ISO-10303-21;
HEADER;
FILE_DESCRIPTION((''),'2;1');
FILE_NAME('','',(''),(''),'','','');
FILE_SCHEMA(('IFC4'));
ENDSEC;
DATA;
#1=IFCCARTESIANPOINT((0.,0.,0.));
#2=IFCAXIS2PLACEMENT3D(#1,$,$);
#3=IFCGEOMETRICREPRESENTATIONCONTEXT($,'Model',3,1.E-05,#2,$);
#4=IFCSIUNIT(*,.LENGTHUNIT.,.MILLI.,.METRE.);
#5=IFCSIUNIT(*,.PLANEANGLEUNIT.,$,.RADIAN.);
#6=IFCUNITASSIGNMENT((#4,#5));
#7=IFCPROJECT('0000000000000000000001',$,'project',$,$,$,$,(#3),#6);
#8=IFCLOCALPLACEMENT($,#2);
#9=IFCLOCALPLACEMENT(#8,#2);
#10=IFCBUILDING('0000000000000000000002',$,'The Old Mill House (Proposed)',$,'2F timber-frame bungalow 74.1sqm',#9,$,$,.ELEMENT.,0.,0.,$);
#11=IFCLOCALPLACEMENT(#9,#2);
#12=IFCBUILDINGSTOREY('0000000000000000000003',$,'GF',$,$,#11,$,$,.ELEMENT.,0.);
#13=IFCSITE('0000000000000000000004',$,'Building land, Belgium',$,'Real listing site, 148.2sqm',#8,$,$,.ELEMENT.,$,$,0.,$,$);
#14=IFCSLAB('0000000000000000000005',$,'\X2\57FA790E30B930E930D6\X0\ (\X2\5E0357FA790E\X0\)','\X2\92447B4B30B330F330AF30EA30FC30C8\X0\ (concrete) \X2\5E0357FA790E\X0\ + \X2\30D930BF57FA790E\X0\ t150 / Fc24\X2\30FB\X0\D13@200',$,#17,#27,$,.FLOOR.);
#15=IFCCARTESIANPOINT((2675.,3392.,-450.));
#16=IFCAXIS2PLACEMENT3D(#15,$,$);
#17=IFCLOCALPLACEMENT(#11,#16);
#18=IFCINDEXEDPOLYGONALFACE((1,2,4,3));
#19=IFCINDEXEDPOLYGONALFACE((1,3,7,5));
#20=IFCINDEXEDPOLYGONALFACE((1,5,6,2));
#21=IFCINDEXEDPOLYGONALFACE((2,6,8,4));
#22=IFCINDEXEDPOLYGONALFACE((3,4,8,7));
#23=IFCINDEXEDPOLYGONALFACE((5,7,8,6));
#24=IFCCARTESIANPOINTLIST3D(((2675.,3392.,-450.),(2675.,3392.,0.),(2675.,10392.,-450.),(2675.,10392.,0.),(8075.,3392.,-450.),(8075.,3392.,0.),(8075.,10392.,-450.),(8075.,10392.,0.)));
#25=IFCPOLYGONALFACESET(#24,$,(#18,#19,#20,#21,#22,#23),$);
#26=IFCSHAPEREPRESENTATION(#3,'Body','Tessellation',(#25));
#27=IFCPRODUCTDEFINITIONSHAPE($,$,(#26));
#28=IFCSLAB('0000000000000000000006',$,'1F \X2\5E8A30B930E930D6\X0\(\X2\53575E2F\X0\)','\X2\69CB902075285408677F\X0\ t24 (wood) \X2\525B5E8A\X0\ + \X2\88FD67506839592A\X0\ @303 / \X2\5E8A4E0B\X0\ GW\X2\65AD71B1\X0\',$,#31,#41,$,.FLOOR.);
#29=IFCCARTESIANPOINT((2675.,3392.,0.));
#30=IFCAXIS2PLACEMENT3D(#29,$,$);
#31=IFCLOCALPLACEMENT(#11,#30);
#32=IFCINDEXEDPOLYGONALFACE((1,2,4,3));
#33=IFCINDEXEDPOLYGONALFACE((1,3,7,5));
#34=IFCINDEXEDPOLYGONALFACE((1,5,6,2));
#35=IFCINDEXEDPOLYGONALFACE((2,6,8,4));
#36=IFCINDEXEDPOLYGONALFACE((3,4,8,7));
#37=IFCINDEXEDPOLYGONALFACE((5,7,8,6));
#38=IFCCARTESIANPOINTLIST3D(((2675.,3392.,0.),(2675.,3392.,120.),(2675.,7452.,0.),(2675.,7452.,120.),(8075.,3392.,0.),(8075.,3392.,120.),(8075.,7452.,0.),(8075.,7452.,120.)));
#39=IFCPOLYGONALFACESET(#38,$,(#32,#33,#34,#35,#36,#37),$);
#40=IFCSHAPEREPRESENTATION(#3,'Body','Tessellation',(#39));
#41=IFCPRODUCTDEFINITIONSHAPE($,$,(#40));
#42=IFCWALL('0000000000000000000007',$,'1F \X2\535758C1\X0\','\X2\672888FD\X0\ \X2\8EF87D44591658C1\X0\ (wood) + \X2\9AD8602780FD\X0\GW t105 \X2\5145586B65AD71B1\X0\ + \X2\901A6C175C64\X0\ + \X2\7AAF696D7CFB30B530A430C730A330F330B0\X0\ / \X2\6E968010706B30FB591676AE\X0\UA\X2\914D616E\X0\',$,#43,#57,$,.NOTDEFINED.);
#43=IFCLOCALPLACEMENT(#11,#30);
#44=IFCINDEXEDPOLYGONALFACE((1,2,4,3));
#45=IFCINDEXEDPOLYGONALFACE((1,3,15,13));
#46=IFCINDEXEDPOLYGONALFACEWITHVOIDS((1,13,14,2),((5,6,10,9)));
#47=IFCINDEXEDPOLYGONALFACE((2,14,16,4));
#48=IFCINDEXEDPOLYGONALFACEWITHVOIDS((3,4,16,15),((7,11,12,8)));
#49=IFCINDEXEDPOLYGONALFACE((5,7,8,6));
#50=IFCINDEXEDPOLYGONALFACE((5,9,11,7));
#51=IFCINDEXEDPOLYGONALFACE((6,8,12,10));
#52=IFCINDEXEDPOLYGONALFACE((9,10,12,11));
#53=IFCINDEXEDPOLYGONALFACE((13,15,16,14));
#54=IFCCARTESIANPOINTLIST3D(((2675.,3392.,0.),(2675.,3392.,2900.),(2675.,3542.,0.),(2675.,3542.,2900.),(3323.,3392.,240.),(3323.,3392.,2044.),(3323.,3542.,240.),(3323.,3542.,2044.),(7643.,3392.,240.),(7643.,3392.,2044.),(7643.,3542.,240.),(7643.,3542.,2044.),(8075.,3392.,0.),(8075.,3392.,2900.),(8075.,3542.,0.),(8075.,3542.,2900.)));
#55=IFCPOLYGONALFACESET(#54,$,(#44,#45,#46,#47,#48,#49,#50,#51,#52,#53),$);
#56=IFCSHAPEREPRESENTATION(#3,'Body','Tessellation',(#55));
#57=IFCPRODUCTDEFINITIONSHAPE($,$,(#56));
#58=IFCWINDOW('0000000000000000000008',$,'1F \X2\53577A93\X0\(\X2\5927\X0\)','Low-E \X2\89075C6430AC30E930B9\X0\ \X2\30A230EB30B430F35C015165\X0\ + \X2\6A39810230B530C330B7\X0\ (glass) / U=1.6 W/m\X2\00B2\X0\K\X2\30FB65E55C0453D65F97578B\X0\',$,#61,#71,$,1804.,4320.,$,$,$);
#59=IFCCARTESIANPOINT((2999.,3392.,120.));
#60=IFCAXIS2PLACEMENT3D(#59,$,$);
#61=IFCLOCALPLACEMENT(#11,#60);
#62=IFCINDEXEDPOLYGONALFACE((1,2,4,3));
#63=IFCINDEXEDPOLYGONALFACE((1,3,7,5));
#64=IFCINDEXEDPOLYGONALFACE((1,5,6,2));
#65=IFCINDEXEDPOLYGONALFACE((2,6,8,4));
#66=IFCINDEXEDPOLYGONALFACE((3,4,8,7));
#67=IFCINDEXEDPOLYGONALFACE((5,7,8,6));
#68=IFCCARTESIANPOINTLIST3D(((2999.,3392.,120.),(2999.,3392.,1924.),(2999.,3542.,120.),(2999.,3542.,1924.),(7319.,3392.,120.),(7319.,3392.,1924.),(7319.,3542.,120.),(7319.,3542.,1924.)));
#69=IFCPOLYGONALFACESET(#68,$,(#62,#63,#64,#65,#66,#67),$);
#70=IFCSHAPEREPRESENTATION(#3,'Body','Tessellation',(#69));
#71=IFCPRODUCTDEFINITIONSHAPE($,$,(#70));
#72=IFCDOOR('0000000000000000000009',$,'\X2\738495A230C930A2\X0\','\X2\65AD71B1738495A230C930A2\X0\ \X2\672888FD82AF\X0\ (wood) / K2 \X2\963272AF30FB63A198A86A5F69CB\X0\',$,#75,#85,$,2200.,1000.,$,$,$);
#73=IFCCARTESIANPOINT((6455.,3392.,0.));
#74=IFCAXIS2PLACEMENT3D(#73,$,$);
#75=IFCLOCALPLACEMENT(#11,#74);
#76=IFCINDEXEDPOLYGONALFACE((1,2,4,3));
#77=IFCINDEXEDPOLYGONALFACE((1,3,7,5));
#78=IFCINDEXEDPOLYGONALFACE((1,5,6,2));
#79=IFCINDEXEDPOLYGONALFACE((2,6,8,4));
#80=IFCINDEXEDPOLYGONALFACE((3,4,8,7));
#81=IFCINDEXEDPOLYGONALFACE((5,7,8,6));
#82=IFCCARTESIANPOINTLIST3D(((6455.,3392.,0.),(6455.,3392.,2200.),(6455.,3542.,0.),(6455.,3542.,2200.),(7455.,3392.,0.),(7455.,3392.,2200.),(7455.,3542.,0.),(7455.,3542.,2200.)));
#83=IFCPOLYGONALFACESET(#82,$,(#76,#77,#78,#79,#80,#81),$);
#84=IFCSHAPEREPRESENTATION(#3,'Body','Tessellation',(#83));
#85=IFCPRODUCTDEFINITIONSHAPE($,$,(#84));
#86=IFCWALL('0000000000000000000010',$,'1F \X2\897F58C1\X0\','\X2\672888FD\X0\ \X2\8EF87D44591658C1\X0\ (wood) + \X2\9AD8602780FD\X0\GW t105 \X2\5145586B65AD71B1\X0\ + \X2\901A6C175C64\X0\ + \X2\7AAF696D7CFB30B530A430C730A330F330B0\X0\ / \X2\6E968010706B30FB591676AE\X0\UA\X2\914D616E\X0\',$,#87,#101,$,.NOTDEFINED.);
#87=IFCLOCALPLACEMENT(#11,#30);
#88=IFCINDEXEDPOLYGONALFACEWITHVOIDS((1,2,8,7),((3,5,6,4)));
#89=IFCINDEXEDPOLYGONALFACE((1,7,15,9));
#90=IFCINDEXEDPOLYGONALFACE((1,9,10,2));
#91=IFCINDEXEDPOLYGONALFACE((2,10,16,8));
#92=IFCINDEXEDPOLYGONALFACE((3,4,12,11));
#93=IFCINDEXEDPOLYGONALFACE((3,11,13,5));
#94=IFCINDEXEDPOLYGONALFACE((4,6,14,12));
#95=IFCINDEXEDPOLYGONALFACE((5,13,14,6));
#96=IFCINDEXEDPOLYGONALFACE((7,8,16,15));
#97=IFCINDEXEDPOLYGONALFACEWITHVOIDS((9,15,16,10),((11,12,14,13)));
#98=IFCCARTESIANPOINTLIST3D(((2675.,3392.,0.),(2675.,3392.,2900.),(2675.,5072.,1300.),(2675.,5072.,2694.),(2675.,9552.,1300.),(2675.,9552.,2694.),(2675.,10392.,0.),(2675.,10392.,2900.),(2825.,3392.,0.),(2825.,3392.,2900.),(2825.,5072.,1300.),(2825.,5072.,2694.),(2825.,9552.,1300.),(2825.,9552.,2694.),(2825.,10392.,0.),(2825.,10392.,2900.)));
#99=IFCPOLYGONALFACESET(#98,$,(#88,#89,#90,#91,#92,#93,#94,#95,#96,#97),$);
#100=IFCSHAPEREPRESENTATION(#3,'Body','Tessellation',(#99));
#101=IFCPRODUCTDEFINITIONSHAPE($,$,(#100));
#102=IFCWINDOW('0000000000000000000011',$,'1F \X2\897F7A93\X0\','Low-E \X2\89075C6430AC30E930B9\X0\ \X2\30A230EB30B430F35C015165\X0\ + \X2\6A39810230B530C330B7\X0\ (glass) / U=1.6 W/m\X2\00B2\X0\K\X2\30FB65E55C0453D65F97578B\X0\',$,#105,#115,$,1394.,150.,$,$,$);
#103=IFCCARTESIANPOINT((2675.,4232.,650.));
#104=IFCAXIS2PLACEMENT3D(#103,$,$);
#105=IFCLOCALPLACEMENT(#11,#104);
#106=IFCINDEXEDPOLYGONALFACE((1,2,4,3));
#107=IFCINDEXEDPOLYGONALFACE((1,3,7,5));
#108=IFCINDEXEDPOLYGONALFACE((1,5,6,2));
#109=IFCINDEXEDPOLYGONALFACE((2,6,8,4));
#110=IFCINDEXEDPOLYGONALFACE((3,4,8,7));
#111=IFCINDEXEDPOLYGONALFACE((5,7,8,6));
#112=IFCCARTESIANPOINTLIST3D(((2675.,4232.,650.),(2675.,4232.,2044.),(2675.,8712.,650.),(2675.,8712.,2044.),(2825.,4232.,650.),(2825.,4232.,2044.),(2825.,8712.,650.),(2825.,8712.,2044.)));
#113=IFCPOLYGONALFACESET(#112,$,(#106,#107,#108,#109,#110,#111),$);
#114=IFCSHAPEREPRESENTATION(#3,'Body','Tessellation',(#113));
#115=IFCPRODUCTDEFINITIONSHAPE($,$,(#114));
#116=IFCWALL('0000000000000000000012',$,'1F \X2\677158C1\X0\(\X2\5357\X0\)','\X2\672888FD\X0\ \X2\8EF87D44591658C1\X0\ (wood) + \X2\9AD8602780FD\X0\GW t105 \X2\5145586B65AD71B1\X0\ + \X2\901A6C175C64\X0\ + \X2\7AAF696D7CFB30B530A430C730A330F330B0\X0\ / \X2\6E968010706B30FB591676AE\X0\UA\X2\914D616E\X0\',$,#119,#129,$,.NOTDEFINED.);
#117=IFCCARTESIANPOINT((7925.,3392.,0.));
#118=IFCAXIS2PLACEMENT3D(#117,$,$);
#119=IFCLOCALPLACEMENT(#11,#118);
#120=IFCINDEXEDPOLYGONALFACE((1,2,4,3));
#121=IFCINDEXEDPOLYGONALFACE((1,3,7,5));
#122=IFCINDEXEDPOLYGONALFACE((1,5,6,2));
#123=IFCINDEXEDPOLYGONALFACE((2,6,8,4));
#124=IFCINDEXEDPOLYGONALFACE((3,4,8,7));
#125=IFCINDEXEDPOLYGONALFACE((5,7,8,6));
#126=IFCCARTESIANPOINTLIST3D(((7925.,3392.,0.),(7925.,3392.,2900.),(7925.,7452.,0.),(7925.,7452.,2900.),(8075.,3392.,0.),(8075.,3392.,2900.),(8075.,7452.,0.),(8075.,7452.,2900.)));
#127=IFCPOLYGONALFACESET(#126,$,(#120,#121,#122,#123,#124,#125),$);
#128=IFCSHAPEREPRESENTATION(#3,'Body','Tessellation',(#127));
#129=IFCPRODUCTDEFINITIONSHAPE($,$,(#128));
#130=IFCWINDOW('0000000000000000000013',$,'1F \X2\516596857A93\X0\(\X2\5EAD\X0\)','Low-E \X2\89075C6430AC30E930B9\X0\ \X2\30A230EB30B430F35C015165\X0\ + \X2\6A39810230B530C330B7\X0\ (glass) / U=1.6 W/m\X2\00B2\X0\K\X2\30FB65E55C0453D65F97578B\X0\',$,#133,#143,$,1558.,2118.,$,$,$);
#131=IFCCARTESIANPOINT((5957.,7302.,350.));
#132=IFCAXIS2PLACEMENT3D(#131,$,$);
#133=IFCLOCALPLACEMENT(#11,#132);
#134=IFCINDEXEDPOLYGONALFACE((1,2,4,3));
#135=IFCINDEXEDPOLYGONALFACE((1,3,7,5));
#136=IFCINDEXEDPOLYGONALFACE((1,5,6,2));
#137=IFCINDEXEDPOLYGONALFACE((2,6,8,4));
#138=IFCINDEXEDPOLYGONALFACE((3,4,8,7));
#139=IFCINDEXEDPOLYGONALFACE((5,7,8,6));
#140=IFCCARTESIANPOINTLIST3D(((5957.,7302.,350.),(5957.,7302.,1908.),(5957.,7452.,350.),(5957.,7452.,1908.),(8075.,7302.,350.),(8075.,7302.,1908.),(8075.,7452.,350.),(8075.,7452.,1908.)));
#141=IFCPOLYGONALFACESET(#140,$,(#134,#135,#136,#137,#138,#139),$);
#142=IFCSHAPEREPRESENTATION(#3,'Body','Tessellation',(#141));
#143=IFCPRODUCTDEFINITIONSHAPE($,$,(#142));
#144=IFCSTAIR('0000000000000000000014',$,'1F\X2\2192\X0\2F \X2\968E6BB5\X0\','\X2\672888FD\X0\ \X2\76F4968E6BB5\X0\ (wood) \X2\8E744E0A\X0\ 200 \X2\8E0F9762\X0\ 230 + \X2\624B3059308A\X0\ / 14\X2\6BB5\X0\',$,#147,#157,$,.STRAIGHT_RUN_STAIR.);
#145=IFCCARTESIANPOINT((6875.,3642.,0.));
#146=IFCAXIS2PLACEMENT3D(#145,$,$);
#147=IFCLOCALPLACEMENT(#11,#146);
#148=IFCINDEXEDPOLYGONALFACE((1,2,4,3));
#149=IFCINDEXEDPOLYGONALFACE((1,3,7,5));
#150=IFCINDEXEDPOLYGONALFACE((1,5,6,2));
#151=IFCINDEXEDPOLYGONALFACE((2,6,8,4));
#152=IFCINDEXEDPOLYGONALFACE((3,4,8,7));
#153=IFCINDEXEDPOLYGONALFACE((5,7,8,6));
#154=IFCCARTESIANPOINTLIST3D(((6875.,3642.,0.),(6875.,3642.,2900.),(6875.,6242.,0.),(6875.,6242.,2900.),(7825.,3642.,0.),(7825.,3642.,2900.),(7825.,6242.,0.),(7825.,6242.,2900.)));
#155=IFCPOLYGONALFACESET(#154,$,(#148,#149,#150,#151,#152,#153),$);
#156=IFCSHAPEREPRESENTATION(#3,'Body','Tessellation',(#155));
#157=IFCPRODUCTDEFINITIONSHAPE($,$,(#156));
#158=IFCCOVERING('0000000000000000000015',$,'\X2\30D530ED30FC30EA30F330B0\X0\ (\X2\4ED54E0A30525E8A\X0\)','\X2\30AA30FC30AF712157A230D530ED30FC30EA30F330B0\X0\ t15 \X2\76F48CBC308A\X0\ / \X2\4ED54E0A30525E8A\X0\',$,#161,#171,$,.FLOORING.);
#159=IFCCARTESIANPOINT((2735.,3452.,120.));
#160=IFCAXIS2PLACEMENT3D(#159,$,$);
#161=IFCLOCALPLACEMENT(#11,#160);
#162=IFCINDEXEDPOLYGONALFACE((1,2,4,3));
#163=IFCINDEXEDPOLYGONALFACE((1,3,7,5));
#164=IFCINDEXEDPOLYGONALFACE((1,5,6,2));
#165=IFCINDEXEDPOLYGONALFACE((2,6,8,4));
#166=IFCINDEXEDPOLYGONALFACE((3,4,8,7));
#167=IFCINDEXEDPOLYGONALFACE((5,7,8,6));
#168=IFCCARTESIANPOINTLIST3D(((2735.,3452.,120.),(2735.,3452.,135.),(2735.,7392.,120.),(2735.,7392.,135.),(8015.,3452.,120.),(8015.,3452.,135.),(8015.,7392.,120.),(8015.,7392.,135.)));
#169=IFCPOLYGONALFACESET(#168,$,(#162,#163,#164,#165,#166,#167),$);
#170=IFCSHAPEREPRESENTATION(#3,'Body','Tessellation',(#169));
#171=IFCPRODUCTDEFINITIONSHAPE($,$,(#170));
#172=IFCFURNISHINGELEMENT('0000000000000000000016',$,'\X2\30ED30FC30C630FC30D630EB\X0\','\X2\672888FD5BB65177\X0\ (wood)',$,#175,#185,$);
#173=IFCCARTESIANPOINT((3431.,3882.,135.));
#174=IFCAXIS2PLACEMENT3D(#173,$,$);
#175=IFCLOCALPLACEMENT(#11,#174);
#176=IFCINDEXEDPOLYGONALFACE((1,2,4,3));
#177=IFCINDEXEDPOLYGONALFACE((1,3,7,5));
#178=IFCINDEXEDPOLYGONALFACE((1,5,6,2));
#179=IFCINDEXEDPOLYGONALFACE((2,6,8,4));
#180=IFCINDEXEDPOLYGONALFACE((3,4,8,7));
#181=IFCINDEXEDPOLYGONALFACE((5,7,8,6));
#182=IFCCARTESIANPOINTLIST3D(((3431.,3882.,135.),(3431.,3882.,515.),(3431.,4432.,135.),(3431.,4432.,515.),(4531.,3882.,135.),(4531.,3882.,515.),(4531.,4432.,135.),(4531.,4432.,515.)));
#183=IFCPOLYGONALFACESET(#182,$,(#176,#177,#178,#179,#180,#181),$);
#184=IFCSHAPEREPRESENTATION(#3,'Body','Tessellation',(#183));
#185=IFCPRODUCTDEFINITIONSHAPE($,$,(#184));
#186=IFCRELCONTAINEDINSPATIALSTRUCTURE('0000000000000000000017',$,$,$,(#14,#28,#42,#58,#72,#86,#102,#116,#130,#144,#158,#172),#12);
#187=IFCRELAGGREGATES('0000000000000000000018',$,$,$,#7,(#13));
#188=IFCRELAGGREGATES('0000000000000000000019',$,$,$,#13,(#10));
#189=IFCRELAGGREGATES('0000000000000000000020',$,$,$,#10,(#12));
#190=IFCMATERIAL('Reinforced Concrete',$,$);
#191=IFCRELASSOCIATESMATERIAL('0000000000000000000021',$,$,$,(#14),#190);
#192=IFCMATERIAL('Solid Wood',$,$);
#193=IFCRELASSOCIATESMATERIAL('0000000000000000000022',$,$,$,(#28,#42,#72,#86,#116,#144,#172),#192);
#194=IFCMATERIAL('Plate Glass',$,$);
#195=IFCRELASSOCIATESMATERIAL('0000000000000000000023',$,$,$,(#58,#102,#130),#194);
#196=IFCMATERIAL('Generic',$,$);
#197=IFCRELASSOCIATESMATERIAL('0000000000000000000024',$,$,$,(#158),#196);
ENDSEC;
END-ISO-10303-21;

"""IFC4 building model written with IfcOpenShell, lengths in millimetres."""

from ifc_helpers import new_model, si_unit, frame, frame_2d, origin, place, context, project, spatial, rectangle, extrude, material, element, fill, save


model = new_model("IFC4")

# Units and contexts
model_context = context("Model", 3, precision=1e-05, world=origin())
ifc_project = project(units=[si_unit("LENGTHUNIT", "METRE", prefix="MILLI"), si_unit("PLANEANGLEUNIT", "RADIAN")], contexts=[model_context])

# Site, building, storey
site_placement = place(None, origin())
site = spatial("IfcSite", under=ifc_project, at=site_placement, Name="Building land, Belgium", ObjectType="Real listing site, 148.2sqm", CompositionType="ELEMENT", RefElevation=0.0)
building_placement = place(site_placement, origin())
building = spatial("IfcBuilding", under=site, at=building_placement, Name="The Old Mill House (Proposed)", ObjectType="2F timber-frame bungalow 74.1sqm", CompositionType="ELEMENT", ElevationOfRefHeight=0.0, ElevationOfTerrain=0.0)
storey_placement = place(building_placement, origin())
storey = spatial("IfcBuildingStorey", under=building, at=storey_placement, Name="GF", CompositionType="ELEMENT", Elevation=0.0)

# Slabs
ifc_material_1 = material(Name="Reinforced Concrete")
slab_1_placement = place(storey_placement, frame((2675.0, 3392.0, -450.0)))
element("IfcSlab", 1, at=slab_1_placement, inside=storey, material=ifc_material_1, Name="基礎スラブ (布基礎)", Description="鉄筋コンクリート (concrete) 布基礎 + ベタ基礎 t150 / Fc24・D13@200", PredefinedType="FLOOR", context=model_context, shape_type="SweptSolid", body=[
    extrude(rectangle(XDim=5400.0, YDim=7000.0, at=frame_2d((2700.0, 3500.0))), frame((2675.0, 3392.0, -450.0)), (0.0, 0.0, 1.0), 450.0),
])
ifc_material_2 = material(Name="Solid Wood")
slab_2_placement = place(storey_placement, frame((2675.0, 3392.0, 0.0)))
element("IfcSlab", 2, at=slab_2_placement, inside=storey, material=ifc_material_2, Name="1F 床スラブ(南帯)", Description="構造用合板 t24 (wood) 剛床 + 製材根太 @303 / 床下 GW断熱", PredefinedType="FLOOR", context=model_context, shape_type="SweptSolid", body=[
    extrude(rectangle(XDim=5400.0, YDim=4060.0, at=frame_2d((2700.0, 2030.0))), frame((2675.0, 3392.0, 0.0)), (0.0, 0.0, 1.0), 120.0),
])

# Wall, openings, window, door
wall_1_placement = place(storey_placement, frame((2675.0, 3392.0, 0.0)))
wall_1 = element("IfcWall", 3, at=wall_1_placement, inside=storey, material=ifc_material_2, Name="1F 南壁", Description="木製 軸組外壁 (wood) + 高性能GW t105 充填断熱 + 通気層 + 窯業系サイディング / 準耐火・外皮UA配慮", PredefinedType="NOTDEFINED", context=model_context, shape_type="SweptSolid", body=[
    extrude(rectangle(XDim=5400.0, YDim=150.0, at=frame_2d((2700.0, 75.0))), frame((2675.0, 3392.0, 0.0)), (0.0, 0.0, 1.0), 2900.0),
])
opening_1_placement = place(storey_placement, frame((2999.0, 3392.0, 120.0)))
opening_1 = element("IfcOpeningElement", 4, at=opening_1_placement, cuts=wall_1, PredefinedType="NOTDEFINED", context=model_context, shape_type="SweptSolid", body=[
    extrude(rectangle(XDim=4320.0, YDim=150.0, at=frame_2d((2160.0, 75.0))), frame((2999.0, 3392.0, 120.0)), (0.0, 0.0, 1.0), 1804.0),
])
opening_2_placement = place(storey_placement, frame((6455.0, 3392.0, 0.0)))
opening_2 = element("IfcOpeningElement", 5, at=opening_2_placement, cuts=wall_1, PredefinedType="NOTDEFINED", context=model_context, shape_type="SweptSolid", body=[
    extrude(rectangle(XDim=1000.0, YDim=150.0, at=frame_2d((500.0, 75.0))), frame((6455.0, 3392.0, 0.0)), (0.0, 0.0, 1.0), 2200.0),
])
ifc_material_3 = material(Name="Plate Glass")
window_1_placement = place(storey_placement, frame((2999.0, 3392.0, 120.0)))
window_1 = element("IfcWindow", 6, at=window_1_placement, inside=storey, material=ifc_material_3, Name="1F 南窓(大)", Description="Low-E 複層ガラス アルゴン封入 + 樹脂サッシ (glass) / U=1.6 W/m²K・日射取得型", OverallHeight=1804.0, OverallWidth=4320.0, context=model_context, shape_type="SweptSolid", body=[
    extrude(rectangle(XDim=4320.0, YDim=150.0, at=frame_2d((2160.0, 75.0))), frame((2999.0, 3392.0, 120.0)), (0.0, 0.0, 1.0), 1804.0),
])
fill(opening_1, window_1)
door_1_placement = place(storey_placement, frame((6455.0, 3392.0, 0.0)))
door_1 = element("IfcDoor", 7, at=door_1_placement, inside=storey, material=ifc_material_2, Name="玄関ドア", Description="断熱玄関ドア 木製芯 (wood) / K2 防犯・採風機構", OverallHeight=2200.0, OverallWidth=1000.0, context=model_context, shape_type="SweptSolid", body=[
    extrude(rectangle(XDim=1000.0, YDim=150.0, at=frame_2d((500.0, 75.0))), frame((6455.0, 3392.0, 0.0)), (0.0, 0.0, 1.0), 2200.0),
])
fill(opening_2, door_1)

# Walls, openings, windows
wall_2_placement = place(storey_placement, frame((2675.0, 3392.0, 0.0)))
wall_2 = element("IfcWall", 8, at=wall_2_placement, inside=storey, material=ifc_material_2, Name="1F 西壁", Description="木製 軸組外壁 (wood) + 高性能GW t105 充填断熱 + 通気層 + 窯業系サイディング / 準耐火・外皮UA配慮", PredefinedType="NOTDEFINED", context=model_context, shape_type="SweptSolid", body=[
    extrude(rectangle(XDim=150.0, YDim=7000.0, at=frame_2d((75.0, 3500.0))), frame((2675.0, 3392.0, 0.0)), (0.0, 0.0, 1.0), 2900.0),
])
opening_3_placement = place(storey_placement, frame((2675.0, 4232.0, 650.0)))
opening_3 = element("IfcOpeningElement", 9, at=opening_3_placement, cuts=wall_2, PredefinedType="NOTDEFINED", context=model_context, shape_type="SweptSolid", body=[
    extrude(rectangle(XDim=150.0, YDim=4480.0, at=frame_2d((75.0, 2240.0))), frame((2675.0, 4232.0, 650.0)), (0.0, 0.0, 1.0), 1394.0),
])
window_2_placement = place(storey_placement, frame((2675.0, 4232.0, 650.0)))
window_2 = element("IfcWindow", 10, at=window_2_placement, inside=storey, material=ifc_material_3, Name="1F 西窓", Description="Low-E 複層ガラス アルゴン封入 + 樹脂サッシ (glass) / U=1.6 W/m²K・日射取得型", OverallHeight=1394.0, OverallWidth=150.0, context=model_context, shape_type="SweptSolid", body=[
    extrude(rectangle(XDim=150.0, YDim=4480.0, at=frame_2d((75.0, 2240.0))), frame((2675.0, 4232.0, 650.0)), (0.0, 0.0, 1.0), 1394.0),
])
fill(opening_3, window_2)
wall_3_placement = place(storey_placement, frame((7925.0, 3392.0, 0.0)))
wall_3 = element("IfcWall", 11, at=wall_3_placement, inside=storey, material=ifc_material_2, Name="1F 東壁(南)", Description="木製 軸組外壁 (wood) + 高性能GW t105 充填断熱 + 通気層 + 窯業系サイディング / 準耐火・外皮UA配慮", PredefinedType="NOTDEFINED", context=model_context, shape_type="SweptSolid", body=[
    extrude(rectangle(XDim=150.0, YDim=4060.0, at=frame_2d((75.0, 2030.0))), frame((7925.0, 3392.0, 0.0)), (0.0, 0.0, 1.0), 2900.0),
])
opening_4_placement = place(storey_placement, frame((5957.0, 7302.0, 350.0)))
opening_4 = element("IfcOpeningElement", 12, at=opening_4_placement, cuts=wall_3, PredefinedType="NOTDEFINED", context=model_context, shape_type="SweptSolid", body=[
    extrude(rectangle(XDim=2118.0, YDim=150.0, at=frame_2d((1059.0, 75.0))), frame((5957.0, 7302.0, 350.0)), (0.0, 0.0, 1.0), 1558.0),
])
window_3_placement = place(storey_placement, frame((5957.0, 7302.0, 350.0)))
window_3 = element("IfcWindow", 13, at=window_3_placement, inside=storey, material=ifc_material_3, Name="1F 入隅窓(庭)", Description="Low-E 複層ガラス アルゴン封入 + 樹脂サッシ (glass) / U=1.6 W/m²K・日射取得型", OverallHeight=1558.0, OverallWidth=2118.0, context=model_context, shape_type="SweptSolid", body=[
    extrude(rectangle(XDim=2118.0, YDim=150.0, at=frame_2d((1059.0, 75.0))), frame((5957.0, 7302.0, 350.0)), (0.0, 0.0, 1.0), 1558.0),
])
fill(opening_4, window_3)

# Stair
stair_placement = place(storey_placement, frame((6875.0, 3642.0, 0.0)))
element("IfcStair", 14, at=stair_placement, inside=storey, material=ifc_material_2, Name="1F→2F 階段", Description="木製 直階段 (wood) 蹴上 200 踏面 230 + 手すり / 14段", PredefinedType="STRAIGHT_RUN_STAIR", context=model_context, shape_type="SweptSolid", body=[
    extrude(rectangle(XDim=950.0, YDim=2600.0, at=frame_2d((475.0, 1300.0))), frame((6875.0, 3642.0, 0.0)), (0.0, 0.0, 1.0), 2900.0),
])

# Covering
ifc_material_4 = material(Name="Generic")
covering_placement = place(storey_placement, frame((2735.0, 3452.0, 120.0)))
element("IfcCovering", 15, at=covering_placement, inside=storey, material=ifc_material_4, Name="フローリング (仕上げ床)", Description="オーク無垢フローリング t15 直貼り / 仕上げ床", PredefinedType="FLOORING", context=model_context, shape_type="SweptSolid", body=[
    extrude(rectangle(XDim=5280.0, YDim=3940.0, at=frame_2d((2640.0, 1970.0))), frame((2735.0, 3452.0, 120.0)), (0.0, 0.0, 1.0), 15.0),
])

# Furnishing element
furnishing_1_placement = place(storey_placement, frame((3431.0, 3882.0, 135.0)))
element("IfcFurnishingElement", 16, at=furnishing_1_placement, inside=storey, material=ifc_material_2, Name="ローテーブル", Description="木製家具 (wood)", context=model_context, shape_type="SweptSolid", body=[
    extrude(rectangle(XDim=1100.0, YDim=550.0, at=frame_2d((550.0, 275.0))), frame((3431.0, 3882.0, 135.0)), (0.0, 0.0, 1.0), 380.0),
])

save(model, "model.ifc")
